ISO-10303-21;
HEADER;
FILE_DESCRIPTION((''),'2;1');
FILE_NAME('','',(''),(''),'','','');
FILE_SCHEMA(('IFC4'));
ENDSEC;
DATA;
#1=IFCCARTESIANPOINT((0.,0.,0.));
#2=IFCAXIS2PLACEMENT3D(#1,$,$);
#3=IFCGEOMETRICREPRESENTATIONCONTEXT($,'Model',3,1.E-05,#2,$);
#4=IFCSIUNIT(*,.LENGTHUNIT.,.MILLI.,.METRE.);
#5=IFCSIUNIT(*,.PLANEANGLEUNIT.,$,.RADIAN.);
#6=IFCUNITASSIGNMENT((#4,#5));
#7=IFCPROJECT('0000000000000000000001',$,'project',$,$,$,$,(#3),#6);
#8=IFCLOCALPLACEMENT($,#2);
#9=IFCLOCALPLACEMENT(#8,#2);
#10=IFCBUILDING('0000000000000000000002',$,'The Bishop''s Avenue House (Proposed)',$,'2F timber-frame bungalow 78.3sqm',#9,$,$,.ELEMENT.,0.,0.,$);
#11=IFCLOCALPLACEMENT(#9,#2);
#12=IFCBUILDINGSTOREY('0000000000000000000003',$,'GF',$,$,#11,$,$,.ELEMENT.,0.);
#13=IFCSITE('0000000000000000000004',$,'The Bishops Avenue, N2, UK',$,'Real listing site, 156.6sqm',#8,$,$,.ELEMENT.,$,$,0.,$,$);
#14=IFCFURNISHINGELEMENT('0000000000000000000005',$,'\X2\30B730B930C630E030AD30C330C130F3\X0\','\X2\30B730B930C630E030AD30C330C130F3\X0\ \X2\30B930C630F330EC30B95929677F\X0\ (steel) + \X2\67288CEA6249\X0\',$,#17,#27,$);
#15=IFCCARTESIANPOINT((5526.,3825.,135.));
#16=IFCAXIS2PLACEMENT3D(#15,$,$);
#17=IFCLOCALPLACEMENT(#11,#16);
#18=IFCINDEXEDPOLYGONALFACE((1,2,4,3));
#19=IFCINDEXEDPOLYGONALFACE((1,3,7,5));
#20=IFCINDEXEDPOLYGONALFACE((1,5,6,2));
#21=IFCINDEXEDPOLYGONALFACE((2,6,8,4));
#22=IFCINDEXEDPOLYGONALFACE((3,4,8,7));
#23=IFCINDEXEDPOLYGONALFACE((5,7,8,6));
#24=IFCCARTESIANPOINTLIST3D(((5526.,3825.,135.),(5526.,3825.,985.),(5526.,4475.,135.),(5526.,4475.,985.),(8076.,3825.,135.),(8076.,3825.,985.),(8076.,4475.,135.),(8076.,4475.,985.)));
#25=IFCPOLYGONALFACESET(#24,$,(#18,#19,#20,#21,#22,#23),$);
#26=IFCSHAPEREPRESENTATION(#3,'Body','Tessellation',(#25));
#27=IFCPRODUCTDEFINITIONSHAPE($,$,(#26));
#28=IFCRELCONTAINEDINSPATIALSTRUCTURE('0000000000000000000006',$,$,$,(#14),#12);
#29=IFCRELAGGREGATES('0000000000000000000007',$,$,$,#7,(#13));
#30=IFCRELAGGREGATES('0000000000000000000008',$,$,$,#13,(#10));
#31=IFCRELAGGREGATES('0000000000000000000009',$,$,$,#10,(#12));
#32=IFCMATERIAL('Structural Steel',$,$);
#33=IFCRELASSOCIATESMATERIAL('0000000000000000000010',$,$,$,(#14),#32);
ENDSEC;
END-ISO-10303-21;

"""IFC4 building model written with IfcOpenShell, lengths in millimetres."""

from ifc_helpers import new_model, si_unit, frame, frame_2d, origin, place, context, project, spatial, rectangle, extrude, material, element, save


model = new_model("IFC4")

# Units and contexts
model_context = context("Model", 3, precision=1e-05, world=origin())
ifc_project = project(units=[si_unit("LENGTHUNIT", "METRE", prefix="MILLI"), si_unit("PLANEANGLEUNIT", "RADIAN")], contexts=[model_context])

# Site, building, storey
site_placement = place(None, origin())
site = spatial("IfcSite", under=ifc_project, at=site_placement, Name="The Bishops Avenue, N2, UK", ObjectType="Real listing site, 156.6sqm", CompositionType="ELEMENT", RefElevation=0.0)
building_placement = place(site_placement, origin())
building = spatial("IfcBuilding", under=site, at=building_placement, Name="The Bishop's Avenue House (Proposed)", ObjectType="2F timber-frame bungalow 78.3sqm", CompositionType="ELEMENT", ElevationOfRefHeight=0.0, ElevationOfTerrain=0.0)
storey_placement = place(building_placement, origin())
storey = spatial("IfcBuildingStorey", under=building, at=storey_placement, Name="GF", CompositionType="ELEMENT", Elevation=0.0)

# Furnishing element
ifc_material_1 = material(Name="Structural Steel")
furnishing_1_placement = place(storey_placement, frame((5526.0, 3825.0, 135.0)))
element("IfcFurnishingElement", 1, at=furnishing_1_placement, inside=storey, material=ifc_material_1, Name="システムキッチン", Description="システムキッチン ステンレス天板 (steel) + 木質扉", context=model_context, shape_type="SweptSolid", body=[
    extrude(rectangle(XDim=2550.0, YDim=650.0, at=frame_2d((1275.0, 325.0))), frame((5526.0, 3825.0, 135.0)), (0.0, 0.0, 1.0), 850.0),
])

save(model, "model.ifc")
